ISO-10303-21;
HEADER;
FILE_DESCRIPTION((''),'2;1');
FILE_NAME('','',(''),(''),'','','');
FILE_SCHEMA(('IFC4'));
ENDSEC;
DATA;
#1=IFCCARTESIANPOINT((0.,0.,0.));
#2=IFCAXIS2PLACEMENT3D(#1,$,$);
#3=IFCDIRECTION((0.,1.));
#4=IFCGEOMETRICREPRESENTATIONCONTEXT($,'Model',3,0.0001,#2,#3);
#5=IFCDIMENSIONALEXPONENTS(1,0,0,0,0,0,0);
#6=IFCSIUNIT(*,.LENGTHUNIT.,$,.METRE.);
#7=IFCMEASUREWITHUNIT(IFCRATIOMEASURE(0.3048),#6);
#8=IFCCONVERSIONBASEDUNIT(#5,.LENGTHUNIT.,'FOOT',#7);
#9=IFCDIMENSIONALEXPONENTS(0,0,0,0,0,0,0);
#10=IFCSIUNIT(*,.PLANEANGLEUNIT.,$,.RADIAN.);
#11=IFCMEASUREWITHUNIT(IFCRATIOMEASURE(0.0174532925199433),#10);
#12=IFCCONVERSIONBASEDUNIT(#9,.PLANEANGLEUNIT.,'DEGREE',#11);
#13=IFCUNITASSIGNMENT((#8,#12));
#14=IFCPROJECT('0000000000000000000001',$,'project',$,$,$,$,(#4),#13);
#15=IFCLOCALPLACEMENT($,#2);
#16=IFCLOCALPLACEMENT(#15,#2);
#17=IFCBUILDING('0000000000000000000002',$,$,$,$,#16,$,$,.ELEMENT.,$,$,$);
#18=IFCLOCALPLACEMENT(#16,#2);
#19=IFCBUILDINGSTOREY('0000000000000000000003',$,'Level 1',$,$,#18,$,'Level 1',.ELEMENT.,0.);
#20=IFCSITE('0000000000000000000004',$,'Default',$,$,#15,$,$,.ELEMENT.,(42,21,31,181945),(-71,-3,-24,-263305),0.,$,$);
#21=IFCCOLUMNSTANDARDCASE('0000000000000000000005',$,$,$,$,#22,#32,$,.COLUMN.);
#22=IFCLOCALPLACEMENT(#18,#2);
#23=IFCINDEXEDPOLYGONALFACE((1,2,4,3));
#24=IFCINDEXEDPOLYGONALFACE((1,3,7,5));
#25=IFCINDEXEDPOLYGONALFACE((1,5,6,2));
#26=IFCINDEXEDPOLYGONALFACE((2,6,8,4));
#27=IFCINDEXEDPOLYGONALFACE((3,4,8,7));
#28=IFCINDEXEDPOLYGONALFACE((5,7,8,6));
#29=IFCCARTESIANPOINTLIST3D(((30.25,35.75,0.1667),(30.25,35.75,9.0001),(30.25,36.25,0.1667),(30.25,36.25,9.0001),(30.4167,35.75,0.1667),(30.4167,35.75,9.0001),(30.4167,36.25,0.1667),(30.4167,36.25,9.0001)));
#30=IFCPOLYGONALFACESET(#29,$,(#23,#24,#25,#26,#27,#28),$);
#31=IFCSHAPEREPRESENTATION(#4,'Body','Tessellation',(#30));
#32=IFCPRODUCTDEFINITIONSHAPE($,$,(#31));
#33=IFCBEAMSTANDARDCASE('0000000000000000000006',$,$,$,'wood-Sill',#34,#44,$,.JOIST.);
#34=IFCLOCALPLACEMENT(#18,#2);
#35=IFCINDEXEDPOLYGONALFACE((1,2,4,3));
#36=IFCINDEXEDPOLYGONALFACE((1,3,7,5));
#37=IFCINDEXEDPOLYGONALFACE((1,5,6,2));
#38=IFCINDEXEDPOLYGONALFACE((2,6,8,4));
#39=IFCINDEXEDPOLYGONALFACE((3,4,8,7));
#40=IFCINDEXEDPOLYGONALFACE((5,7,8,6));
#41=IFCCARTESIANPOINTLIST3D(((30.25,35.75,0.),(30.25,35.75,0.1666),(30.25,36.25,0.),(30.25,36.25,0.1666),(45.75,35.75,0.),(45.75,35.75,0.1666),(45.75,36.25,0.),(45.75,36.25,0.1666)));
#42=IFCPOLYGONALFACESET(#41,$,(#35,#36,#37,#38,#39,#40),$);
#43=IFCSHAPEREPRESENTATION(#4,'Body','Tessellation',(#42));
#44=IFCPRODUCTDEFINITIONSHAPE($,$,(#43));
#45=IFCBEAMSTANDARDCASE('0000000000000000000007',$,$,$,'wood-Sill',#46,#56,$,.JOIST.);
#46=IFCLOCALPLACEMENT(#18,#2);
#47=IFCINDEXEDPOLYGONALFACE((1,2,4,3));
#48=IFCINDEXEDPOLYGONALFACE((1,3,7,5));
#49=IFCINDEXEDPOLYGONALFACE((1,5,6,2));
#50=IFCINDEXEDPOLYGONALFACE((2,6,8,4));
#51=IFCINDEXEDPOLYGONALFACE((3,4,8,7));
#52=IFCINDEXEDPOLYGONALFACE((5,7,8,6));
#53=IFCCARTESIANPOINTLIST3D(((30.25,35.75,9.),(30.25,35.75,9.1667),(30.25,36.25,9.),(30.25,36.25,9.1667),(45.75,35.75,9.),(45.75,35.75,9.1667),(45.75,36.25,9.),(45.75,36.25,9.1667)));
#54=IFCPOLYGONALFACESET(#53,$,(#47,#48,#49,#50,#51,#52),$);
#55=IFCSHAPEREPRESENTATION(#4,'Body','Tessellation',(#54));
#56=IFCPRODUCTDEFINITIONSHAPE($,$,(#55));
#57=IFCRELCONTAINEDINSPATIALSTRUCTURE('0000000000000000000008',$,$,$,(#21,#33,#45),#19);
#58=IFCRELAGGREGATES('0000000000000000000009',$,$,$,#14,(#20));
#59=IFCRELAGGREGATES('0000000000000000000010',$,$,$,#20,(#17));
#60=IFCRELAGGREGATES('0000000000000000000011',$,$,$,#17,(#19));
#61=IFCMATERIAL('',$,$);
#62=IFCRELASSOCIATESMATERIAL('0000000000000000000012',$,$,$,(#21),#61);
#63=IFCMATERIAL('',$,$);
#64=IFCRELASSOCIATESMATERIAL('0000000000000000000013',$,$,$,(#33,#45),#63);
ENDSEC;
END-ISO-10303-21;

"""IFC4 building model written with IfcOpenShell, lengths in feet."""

from ifc_helpers import new_model, entity, si_unit, converted_unit, direction, frame, origin, origin_with_axes, place, context, project, spatial, rectangle, extrude, material, element, save


model = new_model("IFC4")

# Units and contexts
model_context = context("Model", 3, precision=0.0001, world=origin(), true_north=direction((0.0, 1.0)))
ifc_project = project(units=[converted_unit("LENGTHUNIT", "FOOT", entity("IfcRatioMeasure", 0.3048), si_unit("LENGTHUNIT", "METRE"), dimensions=[1, 0, 0, 0, 0, 0, 0]), converted_unit("PLANEANGLEUNIT", "DEGREE", entity("IfcRatioMeasure", 0.0174532925199433), si_unit("PLANEANGLEUNIT", "RADIAN"), dimensions=[0, 0, 0, 0, 0, 0, 0])], contexts=[model_context])

# Site, building, storey
site_placement = place(None, origin())
site = spatial("IfcSite", under=ifc_project, at=site_placement, Name="Default", CompositionType="ELEMENT", RefLatitude=(42, 21, 31, 181945), RefLongitude=(-71, -3, -24, -263305), RefElevation=0.0)
building_placement = place(site_placement, origin())
building = spatial("IfcBuilding", under=site, at=building_placement, CompositionType="ELEMENT")
storey_placement = place(building_placement, origin())
storey = spatial("IfcBuildingStorey", under=building, at=storey_placement, Name="Level 1", LongName="Level 1", CompositionType="ELEMENT", Elevation=0.0)

# Column
ifc_material_1 = material(Name="")
placement_1 = place(storey_placement, frame((30.25, 36.0, 0.0)))
for number, where, z_axis, x_axis in (
    (1, (0.0833, 0.0, 0.1667), (0.0, 0.0, 1.0), (1.0, 0.0, 0.0)),
):
    element("IfcColumnStandardCase", number, at=place(placement_1, frame(where, z_axis=z_axis, x_axis=x_axis)), inside=storey, material=ifc_material_1, PredefinedType="COLUMN", context=model_context, shape_type="SweptSolid", body=[
        extrude(rectangle(XDim=0.1667, YDim=0.5), origin(), (0.0, 0.0, 1.0), 8.8334),
    ])

# Beams
ifc_material_2 = material(Name="")
for number, where, z_axis, x_axis in (
    (2, (0.0, 0.0, 0.0833), (1.0, 0.0, 0.0), (0.0, 0.0, 1.0)),
    (3, (0.0, 0.0, 9.0834), (1.0, 0.0, 0.0), (0.0, 0.0, 1.0)),
):
    element("IfcBeamStandardCase", number, at=place(placement_1, frame(where, z_axis=z_axis, x_axis=x_axis)), inside=storey, material=ifc_material_2, ObjectType="wood-Sill", PredefinedType="JOIST", context=model_context, shape_type="SweptSolid", body=[
        extrude(rectangle(XDim=0.1667, YDim=0.5), origin_with_axes(), (0.0, 0.0, 1.0), 15.5),
    ])

save(model, "model.ifc")
